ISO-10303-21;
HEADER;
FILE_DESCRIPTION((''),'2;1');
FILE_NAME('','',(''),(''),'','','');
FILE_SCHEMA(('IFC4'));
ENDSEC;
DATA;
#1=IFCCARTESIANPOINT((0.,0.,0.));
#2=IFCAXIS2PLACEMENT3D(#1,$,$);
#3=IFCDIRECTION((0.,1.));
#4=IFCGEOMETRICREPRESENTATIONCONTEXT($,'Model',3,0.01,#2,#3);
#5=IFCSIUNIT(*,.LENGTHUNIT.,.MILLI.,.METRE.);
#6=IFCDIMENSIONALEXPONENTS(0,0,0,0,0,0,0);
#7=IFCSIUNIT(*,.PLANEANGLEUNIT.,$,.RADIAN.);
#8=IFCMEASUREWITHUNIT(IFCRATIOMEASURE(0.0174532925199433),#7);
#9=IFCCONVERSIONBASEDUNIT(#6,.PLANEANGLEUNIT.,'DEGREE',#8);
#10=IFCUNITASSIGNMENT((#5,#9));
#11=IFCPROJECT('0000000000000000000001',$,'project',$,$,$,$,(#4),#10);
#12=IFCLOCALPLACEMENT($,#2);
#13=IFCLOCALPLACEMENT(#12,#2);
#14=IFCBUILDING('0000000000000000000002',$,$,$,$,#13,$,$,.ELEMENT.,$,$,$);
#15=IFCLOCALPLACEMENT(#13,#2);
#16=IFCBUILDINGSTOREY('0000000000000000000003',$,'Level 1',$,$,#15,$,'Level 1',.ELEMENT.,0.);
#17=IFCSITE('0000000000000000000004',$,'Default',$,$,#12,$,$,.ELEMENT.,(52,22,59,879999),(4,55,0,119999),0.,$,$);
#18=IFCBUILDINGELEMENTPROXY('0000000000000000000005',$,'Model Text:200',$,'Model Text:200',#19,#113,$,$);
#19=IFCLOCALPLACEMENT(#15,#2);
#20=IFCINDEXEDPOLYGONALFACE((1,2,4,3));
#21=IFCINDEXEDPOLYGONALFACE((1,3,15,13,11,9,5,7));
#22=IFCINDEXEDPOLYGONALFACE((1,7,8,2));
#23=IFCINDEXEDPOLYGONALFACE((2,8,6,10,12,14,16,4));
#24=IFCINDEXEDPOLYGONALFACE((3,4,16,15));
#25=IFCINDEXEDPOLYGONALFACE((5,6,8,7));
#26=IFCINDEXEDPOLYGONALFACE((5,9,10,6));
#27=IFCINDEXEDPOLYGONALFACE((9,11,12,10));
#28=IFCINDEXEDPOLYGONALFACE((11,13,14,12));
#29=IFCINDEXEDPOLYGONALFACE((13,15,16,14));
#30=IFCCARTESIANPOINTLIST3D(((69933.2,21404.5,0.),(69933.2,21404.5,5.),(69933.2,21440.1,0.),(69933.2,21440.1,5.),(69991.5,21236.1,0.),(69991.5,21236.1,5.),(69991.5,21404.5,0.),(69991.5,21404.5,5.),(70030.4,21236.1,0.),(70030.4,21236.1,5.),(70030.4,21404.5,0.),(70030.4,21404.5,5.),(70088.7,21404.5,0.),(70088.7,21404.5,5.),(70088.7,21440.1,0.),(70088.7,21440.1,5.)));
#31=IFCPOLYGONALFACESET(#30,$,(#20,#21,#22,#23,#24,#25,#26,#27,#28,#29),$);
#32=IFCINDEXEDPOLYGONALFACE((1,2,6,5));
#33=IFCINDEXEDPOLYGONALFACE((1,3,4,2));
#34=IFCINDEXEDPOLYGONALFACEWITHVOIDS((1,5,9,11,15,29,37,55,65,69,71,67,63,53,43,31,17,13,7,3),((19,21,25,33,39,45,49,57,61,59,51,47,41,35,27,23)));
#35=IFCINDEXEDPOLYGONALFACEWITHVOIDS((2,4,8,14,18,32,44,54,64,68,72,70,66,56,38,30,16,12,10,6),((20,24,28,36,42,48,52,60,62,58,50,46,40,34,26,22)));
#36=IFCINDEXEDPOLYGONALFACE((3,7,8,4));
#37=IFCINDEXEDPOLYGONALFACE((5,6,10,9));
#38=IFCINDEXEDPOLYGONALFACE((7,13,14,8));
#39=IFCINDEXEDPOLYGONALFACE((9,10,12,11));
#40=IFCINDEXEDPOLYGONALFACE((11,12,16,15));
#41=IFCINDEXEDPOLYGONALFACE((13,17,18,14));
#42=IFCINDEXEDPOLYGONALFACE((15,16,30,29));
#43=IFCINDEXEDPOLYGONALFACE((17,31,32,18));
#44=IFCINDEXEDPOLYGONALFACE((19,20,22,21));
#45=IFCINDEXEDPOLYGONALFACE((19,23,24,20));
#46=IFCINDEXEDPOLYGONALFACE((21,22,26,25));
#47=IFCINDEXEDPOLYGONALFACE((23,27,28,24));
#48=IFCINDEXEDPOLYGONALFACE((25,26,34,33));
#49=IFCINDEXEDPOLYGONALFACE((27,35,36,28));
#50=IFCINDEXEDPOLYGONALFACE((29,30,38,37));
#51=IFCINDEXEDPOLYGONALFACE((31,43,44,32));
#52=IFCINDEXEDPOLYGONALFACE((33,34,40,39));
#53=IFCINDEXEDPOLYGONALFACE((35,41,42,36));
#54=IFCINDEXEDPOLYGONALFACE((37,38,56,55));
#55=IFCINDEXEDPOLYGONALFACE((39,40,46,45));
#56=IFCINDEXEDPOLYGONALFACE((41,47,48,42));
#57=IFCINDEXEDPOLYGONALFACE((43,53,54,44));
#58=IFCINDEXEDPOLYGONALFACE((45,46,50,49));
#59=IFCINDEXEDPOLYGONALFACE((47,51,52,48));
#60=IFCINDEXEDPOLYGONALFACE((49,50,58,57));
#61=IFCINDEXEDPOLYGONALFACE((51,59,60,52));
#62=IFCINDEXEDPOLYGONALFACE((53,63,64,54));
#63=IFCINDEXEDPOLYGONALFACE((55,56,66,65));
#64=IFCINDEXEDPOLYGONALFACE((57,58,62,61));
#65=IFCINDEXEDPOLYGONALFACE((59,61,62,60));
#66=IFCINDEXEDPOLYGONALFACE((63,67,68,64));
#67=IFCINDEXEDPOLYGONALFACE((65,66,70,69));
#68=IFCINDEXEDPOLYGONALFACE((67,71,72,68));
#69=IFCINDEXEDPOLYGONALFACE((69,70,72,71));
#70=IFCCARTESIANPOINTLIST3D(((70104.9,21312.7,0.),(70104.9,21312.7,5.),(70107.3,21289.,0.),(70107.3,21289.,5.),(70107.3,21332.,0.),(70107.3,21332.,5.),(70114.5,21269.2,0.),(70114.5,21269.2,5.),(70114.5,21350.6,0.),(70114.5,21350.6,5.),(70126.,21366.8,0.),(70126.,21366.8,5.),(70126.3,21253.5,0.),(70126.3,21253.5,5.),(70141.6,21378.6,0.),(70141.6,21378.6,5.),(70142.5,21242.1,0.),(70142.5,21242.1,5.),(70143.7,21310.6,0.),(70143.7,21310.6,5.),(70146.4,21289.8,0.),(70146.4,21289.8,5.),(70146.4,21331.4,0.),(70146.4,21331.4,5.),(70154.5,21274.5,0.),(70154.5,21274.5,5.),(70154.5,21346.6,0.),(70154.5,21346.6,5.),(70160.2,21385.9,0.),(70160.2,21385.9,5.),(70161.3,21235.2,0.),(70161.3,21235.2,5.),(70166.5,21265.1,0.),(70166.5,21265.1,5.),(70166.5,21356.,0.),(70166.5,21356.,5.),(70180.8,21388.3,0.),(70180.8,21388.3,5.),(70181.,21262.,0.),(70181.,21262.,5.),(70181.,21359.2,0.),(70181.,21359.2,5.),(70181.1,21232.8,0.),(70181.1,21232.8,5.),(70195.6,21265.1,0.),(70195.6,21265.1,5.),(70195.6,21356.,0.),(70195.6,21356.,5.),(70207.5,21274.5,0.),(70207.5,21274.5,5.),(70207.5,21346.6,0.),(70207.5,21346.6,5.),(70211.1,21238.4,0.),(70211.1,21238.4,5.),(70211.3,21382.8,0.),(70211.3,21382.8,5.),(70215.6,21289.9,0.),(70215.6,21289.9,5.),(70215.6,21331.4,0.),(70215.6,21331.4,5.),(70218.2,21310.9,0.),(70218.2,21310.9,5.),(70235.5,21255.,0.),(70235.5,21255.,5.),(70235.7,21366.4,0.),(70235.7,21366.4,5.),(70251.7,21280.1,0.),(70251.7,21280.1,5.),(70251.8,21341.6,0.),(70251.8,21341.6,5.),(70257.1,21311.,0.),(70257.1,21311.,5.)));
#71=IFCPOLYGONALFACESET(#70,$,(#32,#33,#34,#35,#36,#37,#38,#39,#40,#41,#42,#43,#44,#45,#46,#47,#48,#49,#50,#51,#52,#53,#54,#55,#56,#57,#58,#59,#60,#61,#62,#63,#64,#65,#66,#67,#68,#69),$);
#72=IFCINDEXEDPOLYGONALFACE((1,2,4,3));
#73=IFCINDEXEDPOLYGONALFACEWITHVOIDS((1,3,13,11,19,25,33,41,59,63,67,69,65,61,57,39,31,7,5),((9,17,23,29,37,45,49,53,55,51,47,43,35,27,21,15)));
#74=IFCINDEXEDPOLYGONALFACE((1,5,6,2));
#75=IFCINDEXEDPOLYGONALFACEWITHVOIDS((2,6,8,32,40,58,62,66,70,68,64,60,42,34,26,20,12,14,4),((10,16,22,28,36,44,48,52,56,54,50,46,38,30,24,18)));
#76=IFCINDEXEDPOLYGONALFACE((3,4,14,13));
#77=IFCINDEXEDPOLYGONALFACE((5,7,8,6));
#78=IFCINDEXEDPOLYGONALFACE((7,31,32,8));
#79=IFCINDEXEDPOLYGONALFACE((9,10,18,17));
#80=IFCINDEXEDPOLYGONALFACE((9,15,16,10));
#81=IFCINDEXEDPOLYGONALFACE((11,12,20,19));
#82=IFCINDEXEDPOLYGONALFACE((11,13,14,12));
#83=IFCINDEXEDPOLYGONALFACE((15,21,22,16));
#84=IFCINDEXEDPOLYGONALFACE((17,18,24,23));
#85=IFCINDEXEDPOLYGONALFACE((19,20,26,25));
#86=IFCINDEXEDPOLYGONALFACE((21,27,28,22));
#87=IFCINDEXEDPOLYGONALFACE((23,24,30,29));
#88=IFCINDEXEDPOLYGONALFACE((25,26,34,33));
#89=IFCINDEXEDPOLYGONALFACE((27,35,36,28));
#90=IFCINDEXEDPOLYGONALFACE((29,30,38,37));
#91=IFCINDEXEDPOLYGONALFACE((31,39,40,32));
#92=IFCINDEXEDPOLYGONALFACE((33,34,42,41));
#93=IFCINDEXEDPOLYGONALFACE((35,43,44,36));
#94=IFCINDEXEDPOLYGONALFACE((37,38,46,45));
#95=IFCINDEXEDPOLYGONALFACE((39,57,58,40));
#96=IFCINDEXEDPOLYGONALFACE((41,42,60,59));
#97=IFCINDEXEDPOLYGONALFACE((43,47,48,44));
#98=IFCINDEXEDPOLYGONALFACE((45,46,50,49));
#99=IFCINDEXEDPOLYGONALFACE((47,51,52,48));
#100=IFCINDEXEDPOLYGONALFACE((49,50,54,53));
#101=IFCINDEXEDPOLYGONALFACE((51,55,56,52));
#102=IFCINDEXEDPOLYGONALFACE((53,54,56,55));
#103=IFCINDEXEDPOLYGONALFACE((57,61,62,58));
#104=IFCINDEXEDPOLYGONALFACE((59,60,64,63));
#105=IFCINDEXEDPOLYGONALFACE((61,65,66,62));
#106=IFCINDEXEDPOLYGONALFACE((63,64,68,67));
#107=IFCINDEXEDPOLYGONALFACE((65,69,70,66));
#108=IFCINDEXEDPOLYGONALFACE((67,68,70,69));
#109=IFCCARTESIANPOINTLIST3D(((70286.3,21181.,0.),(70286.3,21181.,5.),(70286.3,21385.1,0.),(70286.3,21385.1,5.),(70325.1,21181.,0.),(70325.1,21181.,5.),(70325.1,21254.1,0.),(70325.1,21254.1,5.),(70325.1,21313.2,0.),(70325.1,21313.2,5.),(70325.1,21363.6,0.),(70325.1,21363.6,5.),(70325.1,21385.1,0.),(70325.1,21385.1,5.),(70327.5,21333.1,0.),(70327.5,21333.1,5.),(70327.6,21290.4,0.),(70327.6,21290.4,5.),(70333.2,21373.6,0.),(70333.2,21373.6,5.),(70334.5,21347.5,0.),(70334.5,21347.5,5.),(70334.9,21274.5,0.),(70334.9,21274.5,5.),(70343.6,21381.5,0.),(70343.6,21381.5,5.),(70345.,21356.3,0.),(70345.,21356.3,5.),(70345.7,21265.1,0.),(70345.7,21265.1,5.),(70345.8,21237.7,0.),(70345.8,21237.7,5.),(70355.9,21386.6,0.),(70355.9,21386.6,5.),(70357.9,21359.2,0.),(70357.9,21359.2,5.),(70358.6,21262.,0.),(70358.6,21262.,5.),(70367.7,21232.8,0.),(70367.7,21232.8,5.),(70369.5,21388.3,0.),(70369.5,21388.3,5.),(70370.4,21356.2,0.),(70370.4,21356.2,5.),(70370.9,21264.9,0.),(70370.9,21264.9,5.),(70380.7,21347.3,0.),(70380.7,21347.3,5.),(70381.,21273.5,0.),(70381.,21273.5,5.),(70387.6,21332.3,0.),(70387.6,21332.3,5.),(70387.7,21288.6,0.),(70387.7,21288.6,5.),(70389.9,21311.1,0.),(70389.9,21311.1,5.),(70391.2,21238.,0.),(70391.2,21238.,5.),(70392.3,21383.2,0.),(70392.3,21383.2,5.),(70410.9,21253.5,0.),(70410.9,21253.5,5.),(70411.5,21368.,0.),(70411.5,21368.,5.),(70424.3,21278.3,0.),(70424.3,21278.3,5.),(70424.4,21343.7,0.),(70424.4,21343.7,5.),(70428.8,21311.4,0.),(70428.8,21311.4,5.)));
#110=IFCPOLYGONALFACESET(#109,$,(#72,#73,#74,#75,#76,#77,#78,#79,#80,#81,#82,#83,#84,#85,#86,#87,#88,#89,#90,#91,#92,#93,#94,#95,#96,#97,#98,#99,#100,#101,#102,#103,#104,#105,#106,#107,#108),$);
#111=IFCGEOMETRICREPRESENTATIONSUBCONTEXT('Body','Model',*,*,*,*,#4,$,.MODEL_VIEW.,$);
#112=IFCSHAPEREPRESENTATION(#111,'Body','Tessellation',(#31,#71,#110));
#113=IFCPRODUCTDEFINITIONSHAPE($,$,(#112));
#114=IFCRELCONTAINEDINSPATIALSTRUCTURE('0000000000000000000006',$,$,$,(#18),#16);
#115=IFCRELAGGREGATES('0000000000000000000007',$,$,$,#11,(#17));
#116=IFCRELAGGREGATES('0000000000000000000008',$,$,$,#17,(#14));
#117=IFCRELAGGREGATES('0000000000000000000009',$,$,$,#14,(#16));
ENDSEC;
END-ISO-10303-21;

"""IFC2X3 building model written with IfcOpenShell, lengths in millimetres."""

from ifc_helpers import new_model, entity, si_unit, converted_unit, direction, frame, origin, place, context, subcontext, project, spatial, polyline, outline, extrude, element, save


model = new_model("IFC2X3")

# Units and contexts
model_context = context("Model", 3, precision=0.01, world=origin(), true_north=direction((0.0, 1.0)))
body_context = subcontext(model_context, "Body", "Model", "MODEL_VIEW")
ifc_project = project(units=[si_unit("LENGTHUNIT", "METRE", prefix="MILLI"), converted_unit("PLANEANGLEUNIT", "DEGREE", entity("IfcRatioMeasure", 0.0174532925199433), si_unit("PLANEANGLEUNIT", "RADIAN"), dimensions=[0, 0, 0, 0, 0, 0, 0])], contexts=[model_context])

# Site, building, storey
site_placement = place(None, origin())
site = spatial("IfcSite", under=ifc_project, at=site_placement, Name="Default", CompositionType="ELEMENT", RefLatitude=(52, 22, 59, 879999), RefLongitude=(4, 55, 0, 119999), RefElevation=0.0)
building_placement = place(site_placement, origin())
building = spatial("IfcBuilding", under=site, at=building_placement, CompositionType="ELEMENT")
storey_placement = place(building_placement, origin())
storey = spatial("IfcBuildingStorey", under=building, at=storey_placement, Name="Level 1", LongName="Level 1", CompositionType="ELEMENT", Elevation=0.0)

# Building element proxy
proxy_1_placement = place(building_placement, origin())
element("IfcBuildingElementProxy", 1, at=proxy_1_placement, inside=storey, Name="Model Text:200", ObjectType="Model Text:200", context=body_context, shape_type="SweptSolid", body=[
    extrude(outline(polyline([(-19.4, -135.2), (19.4, -135.2), (19.4, 33.2), (77.7, 33.2), (77.7, 68.8), (-77.7, 68.8), (-77.7, 33.2), (-19.4, 33.2), (-19.4, -135.2)])), frame((70010.9, 21371.3, 0.0)), (0.0, 0.0, 1.0), 5.0),
    extrude(outline(polyline([(-8.8, -65.7), (15.1, -65.7), (35.5, -60.5), (52.3, -50.4), (65.3, -35.4), (74.1, -17.3), (78.4, 2.1), (75.9, 32.5), (61.8, 58.5), (38.4, 77.1), (8.3, 85.6), (-22.7, 83.3), (-49.0, 69.9), (-67.8, 47.3), (-76.3, 17.5), (-76.0, -3.3), (-70.7, -22.5), (-60.5, -39.2), (-45.5, -52.3), (-27.7, -61.4), (-8.8, -65.7)]), holes=[polyline([(-2.7, -27.2), (-23.1, -22.5), (-37.5, -12.9), (-45.7, 0.0), (-47.3, 14.8), (-42.7, 28.9), (-32.2, 39.9), (-16.3, 46.3), (4.5, 46.9), (25.1, 42.1), (39.6, 32.6), (47.7, 19.7), (49.4, 5.0), (44.8, -9.2), (34.2, -20.2), (18.2, -26.7), (-2.7, -27.2)])]), frame((70171.1, 21310.6, 0.0), z_axis=(0.0, 0.0, 1.0), x_axis=(0.100608, -0.994926, 0.0)), (0.0, 0.0, 1.0), 5.0),
    extrude(outline(polyline([(-73.1, -75.4), (130.9, -75.4), (130.9, -36.6), (57.8, -36.6), (74.3, -15.9), (79.1, 6.0), (73.9, 29.5), (58.4, 49.2), (33.6, 62.6), (0.5, 67.1), (-31.8, 62.8), (-56.1, 49.8), (-71.3, 30.7), (-76.4, 7.8), (-74.7, -5.8), (-69.6, -18.1), (-61.7, -28.5), (-51.7, -36.6), (-73.1, -36.6), (-73.1, -75.4)]), holes=[polyline([(-1.2, -36.6), (-21.2, -34.2), (-35.6, -27.2), (-44.3, -16.7), (-47.2, -3.8), (-44.3, 8.7), (-35.4, 19.0), (-20.4, 25.9), (0.8, 28.2), (23.3, 26.0), (38.5, 19.3), (47.1, 9.2), (49.9, -3.1), (46.8, -16.0), (37.4, -26.8), (21.5, -34.1), (-1.2, -36.6)])]), frame((70361.7, 21311.9, 0.0), z_axis=(0.0, 0.0, 1.0), x_axis=(0.0, -1.0, 0.0)), (0.0, 0.0, 1.0), 5.0),
])

save(model, "model.ifc")
